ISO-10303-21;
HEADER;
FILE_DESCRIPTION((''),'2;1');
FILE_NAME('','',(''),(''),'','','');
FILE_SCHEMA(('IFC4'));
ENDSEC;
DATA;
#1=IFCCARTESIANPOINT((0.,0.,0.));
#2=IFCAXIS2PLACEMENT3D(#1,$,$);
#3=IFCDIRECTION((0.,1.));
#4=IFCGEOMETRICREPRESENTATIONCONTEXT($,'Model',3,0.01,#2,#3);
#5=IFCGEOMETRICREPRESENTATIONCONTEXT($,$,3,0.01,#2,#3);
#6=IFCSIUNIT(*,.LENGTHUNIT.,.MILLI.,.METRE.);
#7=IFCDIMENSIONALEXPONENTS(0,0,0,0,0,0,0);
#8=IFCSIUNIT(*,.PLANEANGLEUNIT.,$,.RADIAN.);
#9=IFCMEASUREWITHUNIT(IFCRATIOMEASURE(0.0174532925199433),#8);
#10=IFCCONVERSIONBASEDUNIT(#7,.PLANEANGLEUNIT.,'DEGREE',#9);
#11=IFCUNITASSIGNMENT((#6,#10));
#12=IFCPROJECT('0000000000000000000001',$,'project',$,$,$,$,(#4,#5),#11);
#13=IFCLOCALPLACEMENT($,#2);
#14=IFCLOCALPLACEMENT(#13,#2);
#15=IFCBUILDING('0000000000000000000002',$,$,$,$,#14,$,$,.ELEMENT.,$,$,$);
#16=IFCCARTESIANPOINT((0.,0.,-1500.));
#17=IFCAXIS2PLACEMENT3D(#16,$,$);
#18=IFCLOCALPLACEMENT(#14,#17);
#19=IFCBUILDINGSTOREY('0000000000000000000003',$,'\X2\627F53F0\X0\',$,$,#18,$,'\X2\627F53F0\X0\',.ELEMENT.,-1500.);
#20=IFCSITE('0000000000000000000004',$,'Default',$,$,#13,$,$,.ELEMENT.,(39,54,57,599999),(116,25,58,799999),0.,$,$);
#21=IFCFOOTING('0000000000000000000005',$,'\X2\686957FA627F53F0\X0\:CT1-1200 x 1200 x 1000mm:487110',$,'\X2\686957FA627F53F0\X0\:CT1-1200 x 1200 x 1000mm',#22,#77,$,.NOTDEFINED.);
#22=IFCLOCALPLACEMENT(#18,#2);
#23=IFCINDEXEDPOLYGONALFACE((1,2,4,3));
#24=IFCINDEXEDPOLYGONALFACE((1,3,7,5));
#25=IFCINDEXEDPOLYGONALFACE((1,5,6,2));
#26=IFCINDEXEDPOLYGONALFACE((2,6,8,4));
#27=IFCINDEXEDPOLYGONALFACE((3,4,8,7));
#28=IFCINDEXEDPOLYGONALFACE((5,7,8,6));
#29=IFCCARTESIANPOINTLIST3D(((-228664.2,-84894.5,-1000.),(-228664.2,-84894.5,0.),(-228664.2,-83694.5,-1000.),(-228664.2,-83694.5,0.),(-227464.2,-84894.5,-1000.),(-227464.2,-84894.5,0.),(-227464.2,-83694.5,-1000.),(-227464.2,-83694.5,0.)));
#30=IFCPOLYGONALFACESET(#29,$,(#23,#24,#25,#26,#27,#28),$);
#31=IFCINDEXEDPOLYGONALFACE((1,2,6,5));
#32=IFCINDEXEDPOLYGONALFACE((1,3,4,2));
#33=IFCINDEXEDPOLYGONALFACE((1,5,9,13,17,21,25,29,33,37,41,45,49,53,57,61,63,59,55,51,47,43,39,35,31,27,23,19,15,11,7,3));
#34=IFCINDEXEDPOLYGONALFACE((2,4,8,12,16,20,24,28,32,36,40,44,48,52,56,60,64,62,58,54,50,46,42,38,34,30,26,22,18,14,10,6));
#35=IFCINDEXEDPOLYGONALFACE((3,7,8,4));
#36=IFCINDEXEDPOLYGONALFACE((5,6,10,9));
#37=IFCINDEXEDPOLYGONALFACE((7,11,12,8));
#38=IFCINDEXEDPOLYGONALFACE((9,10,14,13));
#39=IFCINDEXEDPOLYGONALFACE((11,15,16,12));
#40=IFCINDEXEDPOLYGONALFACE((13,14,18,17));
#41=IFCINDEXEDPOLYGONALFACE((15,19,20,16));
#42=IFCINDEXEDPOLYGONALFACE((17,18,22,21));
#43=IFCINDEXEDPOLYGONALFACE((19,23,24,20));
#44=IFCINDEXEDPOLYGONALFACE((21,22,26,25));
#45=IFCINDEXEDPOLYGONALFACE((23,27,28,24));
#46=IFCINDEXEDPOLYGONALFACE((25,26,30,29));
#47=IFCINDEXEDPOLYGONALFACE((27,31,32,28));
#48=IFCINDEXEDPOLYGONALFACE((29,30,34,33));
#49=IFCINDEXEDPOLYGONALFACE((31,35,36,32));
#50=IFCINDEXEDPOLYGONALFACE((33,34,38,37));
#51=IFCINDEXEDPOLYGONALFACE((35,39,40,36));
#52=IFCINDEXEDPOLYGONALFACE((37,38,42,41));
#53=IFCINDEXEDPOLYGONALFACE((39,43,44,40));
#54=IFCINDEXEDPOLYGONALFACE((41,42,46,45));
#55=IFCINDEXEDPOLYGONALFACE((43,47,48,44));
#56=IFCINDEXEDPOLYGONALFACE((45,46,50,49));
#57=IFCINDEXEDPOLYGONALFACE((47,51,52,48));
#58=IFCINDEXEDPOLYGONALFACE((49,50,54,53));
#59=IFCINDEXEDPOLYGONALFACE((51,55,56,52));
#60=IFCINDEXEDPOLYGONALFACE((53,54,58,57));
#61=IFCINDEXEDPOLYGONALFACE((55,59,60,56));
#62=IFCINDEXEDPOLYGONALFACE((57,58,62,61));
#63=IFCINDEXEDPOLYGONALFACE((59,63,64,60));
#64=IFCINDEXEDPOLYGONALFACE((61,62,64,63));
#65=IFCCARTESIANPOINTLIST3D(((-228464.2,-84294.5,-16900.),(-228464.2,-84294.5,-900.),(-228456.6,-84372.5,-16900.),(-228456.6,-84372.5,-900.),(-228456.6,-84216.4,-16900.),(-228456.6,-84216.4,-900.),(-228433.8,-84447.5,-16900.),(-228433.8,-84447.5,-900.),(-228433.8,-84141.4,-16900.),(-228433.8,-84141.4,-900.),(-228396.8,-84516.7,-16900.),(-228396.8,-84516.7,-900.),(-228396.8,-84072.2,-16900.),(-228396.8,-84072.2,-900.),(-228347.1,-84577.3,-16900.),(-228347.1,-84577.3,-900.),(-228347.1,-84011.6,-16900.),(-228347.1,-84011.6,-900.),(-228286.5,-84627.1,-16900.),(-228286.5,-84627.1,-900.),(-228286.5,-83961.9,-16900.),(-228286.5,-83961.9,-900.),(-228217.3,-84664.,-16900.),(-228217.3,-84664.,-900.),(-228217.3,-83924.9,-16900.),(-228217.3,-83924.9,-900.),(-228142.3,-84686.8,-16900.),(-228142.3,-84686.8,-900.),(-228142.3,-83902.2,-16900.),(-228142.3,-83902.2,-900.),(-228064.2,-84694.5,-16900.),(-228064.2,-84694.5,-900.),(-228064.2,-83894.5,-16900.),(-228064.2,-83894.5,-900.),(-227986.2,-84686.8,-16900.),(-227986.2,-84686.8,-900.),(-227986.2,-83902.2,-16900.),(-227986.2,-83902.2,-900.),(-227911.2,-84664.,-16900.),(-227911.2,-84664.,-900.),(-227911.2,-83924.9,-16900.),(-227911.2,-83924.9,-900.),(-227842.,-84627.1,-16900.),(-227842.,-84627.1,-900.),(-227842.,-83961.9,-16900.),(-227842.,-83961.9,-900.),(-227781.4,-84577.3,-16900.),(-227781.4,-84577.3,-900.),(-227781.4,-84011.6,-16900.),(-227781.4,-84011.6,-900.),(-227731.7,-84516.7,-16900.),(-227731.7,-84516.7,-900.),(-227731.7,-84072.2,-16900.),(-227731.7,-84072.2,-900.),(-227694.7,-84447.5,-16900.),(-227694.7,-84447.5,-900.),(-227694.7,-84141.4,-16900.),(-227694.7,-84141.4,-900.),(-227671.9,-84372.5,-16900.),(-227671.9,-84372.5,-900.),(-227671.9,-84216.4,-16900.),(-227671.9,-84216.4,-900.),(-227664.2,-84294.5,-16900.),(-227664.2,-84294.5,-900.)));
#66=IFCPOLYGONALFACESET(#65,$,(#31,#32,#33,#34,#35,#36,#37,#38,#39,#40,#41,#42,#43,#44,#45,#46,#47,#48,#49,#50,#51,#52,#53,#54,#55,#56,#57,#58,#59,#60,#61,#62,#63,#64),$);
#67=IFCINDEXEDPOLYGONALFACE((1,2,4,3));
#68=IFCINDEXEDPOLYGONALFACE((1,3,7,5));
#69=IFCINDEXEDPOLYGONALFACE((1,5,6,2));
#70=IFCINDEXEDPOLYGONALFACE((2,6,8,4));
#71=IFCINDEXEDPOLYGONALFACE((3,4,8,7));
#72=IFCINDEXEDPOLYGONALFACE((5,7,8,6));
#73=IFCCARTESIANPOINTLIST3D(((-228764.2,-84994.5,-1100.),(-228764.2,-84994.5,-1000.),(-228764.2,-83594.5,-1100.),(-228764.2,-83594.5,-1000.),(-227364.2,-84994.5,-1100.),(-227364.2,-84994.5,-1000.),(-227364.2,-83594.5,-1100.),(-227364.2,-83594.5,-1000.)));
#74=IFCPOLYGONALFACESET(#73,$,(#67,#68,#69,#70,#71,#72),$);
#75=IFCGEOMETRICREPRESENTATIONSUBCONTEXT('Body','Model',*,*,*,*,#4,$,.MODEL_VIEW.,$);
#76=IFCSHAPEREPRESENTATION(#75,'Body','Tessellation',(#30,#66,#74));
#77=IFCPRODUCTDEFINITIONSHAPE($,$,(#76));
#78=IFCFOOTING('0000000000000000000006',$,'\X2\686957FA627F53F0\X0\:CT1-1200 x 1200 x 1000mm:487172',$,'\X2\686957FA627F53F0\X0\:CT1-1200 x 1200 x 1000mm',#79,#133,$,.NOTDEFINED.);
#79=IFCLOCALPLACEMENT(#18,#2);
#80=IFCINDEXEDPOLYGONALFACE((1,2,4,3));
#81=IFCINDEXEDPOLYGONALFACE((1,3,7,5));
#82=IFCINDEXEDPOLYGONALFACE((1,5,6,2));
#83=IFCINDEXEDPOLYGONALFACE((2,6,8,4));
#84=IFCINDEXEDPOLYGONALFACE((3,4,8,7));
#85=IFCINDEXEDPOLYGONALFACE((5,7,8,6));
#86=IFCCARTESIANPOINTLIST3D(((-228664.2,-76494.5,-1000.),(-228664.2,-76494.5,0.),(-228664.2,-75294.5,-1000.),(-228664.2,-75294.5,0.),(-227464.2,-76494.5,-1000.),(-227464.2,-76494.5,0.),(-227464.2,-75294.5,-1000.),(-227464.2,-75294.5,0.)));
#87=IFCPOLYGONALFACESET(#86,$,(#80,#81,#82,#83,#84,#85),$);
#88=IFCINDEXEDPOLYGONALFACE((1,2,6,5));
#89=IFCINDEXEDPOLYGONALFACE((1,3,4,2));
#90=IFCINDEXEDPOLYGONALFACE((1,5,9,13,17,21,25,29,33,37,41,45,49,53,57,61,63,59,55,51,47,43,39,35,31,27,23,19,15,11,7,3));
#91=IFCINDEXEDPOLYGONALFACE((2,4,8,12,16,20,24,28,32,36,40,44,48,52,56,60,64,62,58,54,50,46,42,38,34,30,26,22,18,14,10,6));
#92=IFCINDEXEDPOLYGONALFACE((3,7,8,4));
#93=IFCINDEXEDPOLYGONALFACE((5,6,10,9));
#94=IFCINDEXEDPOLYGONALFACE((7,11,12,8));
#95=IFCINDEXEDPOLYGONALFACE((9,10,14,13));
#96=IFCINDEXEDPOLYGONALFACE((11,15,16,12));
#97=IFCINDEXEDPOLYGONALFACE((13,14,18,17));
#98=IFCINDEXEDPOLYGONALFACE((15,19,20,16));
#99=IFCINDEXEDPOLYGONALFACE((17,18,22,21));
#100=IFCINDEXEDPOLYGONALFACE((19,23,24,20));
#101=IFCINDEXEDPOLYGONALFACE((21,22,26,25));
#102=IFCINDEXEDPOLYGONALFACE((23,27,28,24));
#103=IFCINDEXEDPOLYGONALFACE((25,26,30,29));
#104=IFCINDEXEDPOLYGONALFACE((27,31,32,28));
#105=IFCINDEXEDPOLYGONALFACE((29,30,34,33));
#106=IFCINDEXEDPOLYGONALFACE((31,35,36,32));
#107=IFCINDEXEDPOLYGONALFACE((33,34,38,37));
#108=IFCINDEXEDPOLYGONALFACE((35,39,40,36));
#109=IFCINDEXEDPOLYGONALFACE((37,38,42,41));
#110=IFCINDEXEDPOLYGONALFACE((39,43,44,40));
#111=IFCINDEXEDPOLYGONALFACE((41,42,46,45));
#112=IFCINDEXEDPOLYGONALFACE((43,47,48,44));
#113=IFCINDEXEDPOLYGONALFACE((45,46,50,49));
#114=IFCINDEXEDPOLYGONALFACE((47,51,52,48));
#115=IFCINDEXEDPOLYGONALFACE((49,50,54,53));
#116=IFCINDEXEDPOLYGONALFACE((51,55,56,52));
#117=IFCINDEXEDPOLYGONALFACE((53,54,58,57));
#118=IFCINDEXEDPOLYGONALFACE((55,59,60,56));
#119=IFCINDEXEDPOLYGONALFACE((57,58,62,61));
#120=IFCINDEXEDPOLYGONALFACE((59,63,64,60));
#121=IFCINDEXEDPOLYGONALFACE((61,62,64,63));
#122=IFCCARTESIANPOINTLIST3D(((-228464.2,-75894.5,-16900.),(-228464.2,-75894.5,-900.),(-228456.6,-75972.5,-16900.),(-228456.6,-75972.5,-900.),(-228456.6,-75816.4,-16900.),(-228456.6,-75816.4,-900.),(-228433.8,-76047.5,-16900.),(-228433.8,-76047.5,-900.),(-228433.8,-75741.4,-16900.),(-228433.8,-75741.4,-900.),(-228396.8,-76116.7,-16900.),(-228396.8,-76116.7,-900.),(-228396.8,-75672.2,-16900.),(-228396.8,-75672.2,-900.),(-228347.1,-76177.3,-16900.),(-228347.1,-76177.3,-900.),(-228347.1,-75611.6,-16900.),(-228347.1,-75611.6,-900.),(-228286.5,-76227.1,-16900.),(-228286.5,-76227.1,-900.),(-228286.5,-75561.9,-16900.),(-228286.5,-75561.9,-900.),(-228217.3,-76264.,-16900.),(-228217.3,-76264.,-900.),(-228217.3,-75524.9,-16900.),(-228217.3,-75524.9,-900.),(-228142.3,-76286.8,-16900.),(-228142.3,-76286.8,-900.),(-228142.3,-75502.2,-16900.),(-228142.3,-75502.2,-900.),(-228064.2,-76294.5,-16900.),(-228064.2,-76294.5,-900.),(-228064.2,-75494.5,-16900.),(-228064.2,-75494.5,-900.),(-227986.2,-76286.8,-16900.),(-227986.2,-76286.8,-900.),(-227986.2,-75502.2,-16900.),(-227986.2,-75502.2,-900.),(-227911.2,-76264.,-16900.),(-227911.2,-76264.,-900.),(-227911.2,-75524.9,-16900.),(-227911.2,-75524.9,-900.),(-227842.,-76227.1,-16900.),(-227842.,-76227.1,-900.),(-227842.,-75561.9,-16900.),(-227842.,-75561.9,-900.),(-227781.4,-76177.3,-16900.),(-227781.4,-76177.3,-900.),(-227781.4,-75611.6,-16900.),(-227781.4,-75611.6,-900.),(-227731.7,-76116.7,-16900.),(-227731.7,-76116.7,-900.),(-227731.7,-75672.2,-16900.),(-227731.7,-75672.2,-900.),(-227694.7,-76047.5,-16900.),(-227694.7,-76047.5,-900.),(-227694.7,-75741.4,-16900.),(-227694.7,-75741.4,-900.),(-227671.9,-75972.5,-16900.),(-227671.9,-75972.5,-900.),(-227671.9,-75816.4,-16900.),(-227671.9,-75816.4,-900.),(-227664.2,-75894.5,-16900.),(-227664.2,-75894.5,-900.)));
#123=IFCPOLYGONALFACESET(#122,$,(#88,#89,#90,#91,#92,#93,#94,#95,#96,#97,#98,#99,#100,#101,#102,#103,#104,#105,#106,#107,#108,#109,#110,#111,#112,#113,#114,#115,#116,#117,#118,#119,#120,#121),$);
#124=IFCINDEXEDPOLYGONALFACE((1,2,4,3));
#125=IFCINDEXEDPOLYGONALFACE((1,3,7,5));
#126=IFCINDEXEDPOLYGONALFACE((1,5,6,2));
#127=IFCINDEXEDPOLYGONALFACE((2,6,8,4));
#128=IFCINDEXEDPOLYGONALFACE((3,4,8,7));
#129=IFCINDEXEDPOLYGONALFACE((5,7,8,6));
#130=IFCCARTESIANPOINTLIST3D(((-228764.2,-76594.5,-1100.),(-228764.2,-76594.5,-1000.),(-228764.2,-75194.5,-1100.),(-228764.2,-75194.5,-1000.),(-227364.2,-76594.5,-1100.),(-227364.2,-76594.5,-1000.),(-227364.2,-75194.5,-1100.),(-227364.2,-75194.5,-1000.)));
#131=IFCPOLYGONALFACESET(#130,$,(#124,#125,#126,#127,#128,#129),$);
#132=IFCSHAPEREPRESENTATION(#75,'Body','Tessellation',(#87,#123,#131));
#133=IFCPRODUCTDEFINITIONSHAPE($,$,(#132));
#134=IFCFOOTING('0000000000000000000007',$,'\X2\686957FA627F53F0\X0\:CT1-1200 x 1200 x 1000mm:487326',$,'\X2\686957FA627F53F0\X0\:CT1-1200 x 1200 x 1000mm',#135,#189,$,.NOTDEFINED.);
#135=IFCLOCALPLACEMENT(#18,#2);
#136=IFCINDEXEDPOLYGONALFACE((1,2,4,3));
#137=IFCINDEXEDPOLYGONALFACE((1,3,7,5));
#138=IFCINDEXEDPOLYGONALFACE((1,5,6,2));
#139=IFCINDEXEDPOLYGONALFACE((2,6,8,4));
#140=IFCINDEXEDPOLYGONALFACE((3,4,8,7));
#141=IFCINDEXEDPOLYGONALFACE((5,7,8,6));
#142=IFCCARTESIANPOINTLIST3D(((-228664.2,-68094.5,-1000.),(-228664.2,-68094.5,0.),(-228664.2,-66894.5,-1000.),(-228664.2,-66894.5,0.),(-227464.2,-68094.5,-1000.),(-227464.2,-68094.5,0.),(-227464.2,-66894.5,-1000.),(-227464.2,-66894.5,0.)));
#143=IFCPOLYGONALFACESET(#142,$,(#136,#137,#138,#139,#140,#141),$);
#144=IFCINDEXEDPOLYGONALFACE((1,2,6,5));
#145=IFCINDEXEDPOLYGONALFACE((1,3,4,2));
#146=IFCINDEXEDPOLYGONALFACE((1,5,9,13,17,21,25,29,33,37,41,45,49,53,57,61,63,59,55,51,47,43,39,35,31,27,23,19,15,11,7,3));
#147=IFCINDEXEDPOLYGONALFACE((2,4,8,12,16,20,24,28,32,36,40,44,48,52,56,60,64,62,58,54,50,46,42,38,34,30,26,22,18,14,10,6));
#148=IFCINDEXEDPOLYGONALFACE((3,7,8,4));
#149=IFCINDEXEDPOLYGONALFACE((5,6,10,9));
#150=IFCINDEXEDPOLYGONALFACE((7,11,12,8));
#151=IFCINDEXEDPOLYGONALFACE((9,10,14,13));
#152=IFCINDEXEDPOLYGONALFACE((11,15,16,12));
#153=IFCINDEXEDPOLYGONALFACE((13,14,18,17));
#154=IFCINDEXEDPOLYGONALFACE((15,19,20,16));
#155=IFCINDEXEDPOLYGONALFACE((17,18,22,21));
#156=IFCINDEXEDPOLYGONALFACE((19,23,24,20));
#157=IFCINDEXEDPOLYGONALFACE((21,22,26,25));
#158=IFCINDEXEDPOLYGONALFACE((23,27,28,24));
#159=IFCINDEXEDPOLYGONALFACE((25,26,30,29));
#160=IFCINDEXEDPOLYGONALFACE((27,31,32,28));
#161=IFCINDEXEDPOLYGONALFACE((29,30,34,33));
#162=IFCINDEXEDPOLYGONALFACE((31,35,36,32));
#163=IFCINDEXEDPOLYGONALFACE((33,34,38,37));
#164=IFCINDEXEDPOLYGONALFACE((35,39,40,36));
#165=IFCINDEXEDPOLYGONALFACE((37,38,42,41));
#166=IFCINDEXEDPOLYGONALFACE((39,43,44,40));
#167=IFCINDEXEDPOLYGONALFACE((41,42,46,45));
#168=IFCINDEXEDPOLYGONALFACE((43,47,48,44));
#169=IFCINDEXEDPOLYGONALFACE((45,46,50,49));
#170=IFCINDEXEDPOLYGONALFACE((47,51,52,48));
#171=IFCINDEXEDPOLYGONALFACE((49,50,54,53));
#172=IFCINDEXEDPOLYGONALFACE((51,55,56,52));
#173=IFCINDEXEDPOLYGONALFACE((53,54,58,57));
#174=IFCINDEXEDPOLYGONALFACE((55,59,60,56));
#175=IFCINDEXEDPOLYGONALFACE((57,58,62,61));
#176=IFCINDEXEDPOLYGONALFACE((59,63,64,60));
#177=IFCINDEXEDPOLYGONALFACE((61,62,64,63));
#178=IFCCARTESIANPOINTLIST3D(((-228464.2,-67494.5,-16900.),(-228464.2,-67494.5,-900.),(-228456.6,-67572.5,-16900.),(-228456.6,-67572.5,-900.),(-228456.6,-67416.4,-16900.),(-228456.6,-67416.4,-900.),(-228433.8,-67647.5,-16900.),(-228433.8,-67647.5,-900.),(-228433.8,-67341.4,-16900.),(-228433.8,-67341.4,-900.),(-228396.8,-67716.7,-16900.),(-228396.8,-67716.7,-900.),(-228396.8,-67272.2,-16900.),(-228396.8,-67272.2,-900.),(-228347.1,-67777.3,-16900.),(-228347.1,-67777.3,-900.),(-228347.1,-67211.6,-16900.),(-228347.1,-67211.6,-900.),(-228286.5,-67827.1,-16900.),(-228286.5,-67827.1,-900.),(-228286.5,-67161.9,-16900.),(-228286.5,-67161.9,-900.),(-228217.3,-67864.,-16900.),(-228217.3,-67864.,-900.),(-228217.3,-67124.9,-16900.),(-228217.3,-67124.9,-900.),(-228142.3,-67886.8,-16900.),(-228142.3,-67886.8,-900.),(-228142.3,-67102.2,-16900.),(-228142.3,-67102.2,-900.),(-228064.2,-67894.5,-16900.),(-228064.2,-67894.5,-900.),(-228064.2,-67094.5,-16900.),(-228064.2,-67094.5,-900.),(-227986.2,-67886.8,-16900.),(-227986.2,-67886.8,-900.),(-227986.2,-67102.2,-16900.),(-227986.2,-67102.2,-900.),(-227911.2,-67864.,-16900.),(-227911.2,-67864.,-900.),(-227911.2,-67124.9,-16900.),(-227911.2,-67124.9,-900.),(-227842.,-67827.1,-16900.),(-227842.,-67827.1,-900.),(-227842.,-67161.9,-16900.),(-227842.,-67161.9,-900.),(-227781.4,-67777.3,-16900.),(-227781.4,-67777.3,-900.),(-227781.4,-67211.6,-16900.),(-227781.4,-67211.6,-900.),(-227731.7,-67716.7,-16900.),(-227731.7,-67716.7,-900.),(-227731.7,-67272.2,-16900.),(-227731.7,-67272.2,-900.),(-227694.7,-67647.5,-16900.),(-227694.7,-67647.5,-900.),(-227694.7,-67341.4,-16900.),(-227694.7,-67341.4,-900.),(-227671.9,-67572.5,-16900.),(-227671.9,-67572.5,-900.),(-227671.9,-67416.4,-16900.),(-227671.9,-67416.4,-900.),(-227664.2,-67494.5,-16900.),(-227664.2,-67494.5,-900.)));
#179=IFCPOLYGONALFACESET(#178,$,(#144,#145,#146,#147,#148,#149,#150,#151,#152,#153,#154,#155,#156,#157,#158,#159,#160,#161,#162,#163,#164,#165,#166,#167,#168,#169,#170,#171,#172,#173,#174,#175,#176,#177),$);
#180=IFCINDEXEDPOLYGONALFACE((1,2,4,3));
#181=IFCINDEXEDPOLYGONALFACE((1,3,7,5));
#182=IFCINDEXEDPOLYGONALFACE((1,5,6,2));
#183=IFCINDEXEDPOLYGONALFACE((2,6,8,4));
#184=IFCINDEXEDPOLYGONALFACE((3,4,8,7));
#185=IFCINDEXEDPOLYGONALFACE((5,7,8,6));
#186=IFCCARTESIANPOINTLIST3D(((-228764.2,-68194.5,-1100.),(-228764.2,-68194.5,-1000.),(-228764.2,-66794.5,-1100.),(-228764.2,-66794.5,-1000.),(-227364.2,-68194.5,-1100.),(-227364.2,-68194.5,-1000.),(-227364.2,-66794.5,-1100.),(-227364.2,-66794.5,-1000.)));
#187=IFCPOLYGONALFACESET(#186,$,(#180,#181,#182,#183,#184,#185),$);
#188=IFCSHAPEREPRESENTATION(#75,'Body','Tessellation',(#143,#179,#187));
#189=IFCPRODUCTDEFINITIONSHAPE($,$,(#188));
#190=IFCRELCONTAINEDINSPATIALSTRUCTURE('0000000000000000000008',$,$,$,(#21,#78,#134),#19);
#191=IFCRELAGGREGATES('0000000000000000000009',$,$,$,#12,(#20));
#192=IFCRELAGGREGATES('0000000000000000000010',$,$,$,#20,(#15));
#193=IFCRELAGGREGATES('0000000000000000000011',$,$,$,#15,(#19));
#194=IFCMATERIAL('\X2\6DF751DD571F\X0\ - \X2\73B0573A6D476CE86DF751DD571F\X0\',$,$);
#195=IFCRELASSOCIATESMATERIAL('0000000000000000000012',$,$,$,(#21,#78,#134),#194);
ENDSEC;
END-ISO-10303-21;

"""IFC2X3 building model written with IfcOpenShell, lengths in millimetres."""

from ifc_helpers import new_model, entity, si_unit, converted_unit, direction, frame, frame_2d, origin, origin_2d_with_axis, place, context, subcontext, project, spatial, rectangle, circle, extrude, material, element, save


model = new_model("IFC2X3")

# Units and contexts
model_context = context("Model", 3, precision=0.01, world=origin(), true_north=direction((0.0, 1.0)))
context_of_model = context(None, 3, precision=0.01, world=origin(), true_north=direction((0.0, 1.0)))
body_context = subcontext(model_context, "Body", "Model", "MODEL_VIEW")
ifc_project = project(units=[si_unit("LENGTHUNIT", "METRE", prefix="MILLI"), converted_unit("PLANEANGLEUNIT", "DEGREE", entity("IfcRatioMeasure", 0.0174532925199433), si_unit("PLANEANGLEUNIT", "RADIAN"), dimensions=[0, 0, 0, 0, 0, 0, 0])], contexts=[model_context, context_of_model])

# Site, building, storey
site_placement = place(None, origin())
site = spatial("IfcSite", under=ifc_project, at=site_placement, Name="Default", CompositionType="ELEMENT", RefLatitude=(39, 54, 57, 599999), RefLongitude=(116, 25, 58, 799999), RefElevation=0.0)
building_placement = place(site_placement, origin())
building = spatial("IfcBuilding", under=site, at=building_placement, CompositionType="ELEMENT")
storey_placement = place(building_placement, frame((0.0, 0.0, -1500.0)))
storey = spatial("IfcBuildingStorey", under=building, at=storey_placement, Name="承台", LongName="承台", CompositionType="ELEMENT", Elevation=-1500.0)

# Footings
ifc_material_1 = material(Name="混凝土 - 现场浇注混凝土")
footing_1_placement = place(storey_placement, frame((-228764.2, -84994.5, -16900.0)))
element("IfcFooting", 1, at=footing_1_placement, inside=storey, material=ifc_material_1, Name="桩基承台:CT1-1200 x 1200 x 1000mm:487110", ObjectType="桩基承台:CT1-1200 x 1200 x 1000mm", PredefinedType="NOTDEFINED", context=body_context, shape_type="SweptSolid", body=[
    extrude(rectangle(XDim=1200.0, YDim=1200.0, at=origin_2d_with_axis()), frame((700.0, 700.0, 15900.0), z_axis=(0.0, 0.0, 1.0), x_axis=(-1.0, 0.0, 0.0)), (0.0, 0.0, 1.0), 1000.0),
    extrude(circle(Radius=400.0, at=origin_2d_with_axis()), frame((700.0, 700.0, 0.0)), (0.0, 0.0, 1.0), 16000.0),
    extrude(rectangle(XDim=1400.0, YDim=1400.0, at=frame_2d((0.0, 0.0), x_axis=(1.0, 0.0))), frame((700.0, 700.0, 15800.0), z_axis=(0.0, 0.0, 1.0), x_axis=(0.0, 1.0, 0.0)), (0.0, 0.0, 1.0), 100.0),
])
for number, where, name in (
    (2, (-228764.2, -76594.5, -16900.0), "桩基承台:CT1-1200 x 1200 x 1000mm:487172"),
    (3, (-228764.2, -68194.5, -16900.0), "桩基承台:CT1-1200 x 1200 x 1000mm:487326"),
):
    element("IfcFooting", number, at=place(storey_placement, frame(where)), inside=storey, material=ifc_material_1, Name=name, ObjectType="桩基承台:CT1-1200 x 1200 x 1000mm", PredefinedType="NOTDEFINED", context=body_context, shape_type="SweptSolid", body=[
        extrude(rectangle(XDim=1200.0, YDim=1200.0, at=frame_2d((0.0, 0.0), x_axis=(1.0, 0.0))), frame((700.0, 700.0, 15900.0), z_axis=(0.0, 0.0, 1.0), x_axis=(-1.0, 0.0, 0.0)), (0.0, 0.0, 1.0), 1000.0),
        extrude(circle(Radius=400.0, at=origin_2d_with_axis()), frame((700.0, 700.0, 0.0)), (0.0, 0.0, 1.0), 16000.0),
        extrude(rectangle(XDim=1400.0, YDim=1400.0, at=frame_2d((0.0, 0.0), x_axis=(1.0, 0.0))), frame((700.0, 700.0, 15800.0), z_axis=(0.0, 0.0, 1.0), x_axis=(0.0, 1.0, 0.0)), (0.0, 0.0, 1.0), 100.0),
    ])

save(model, "model.ifc")
